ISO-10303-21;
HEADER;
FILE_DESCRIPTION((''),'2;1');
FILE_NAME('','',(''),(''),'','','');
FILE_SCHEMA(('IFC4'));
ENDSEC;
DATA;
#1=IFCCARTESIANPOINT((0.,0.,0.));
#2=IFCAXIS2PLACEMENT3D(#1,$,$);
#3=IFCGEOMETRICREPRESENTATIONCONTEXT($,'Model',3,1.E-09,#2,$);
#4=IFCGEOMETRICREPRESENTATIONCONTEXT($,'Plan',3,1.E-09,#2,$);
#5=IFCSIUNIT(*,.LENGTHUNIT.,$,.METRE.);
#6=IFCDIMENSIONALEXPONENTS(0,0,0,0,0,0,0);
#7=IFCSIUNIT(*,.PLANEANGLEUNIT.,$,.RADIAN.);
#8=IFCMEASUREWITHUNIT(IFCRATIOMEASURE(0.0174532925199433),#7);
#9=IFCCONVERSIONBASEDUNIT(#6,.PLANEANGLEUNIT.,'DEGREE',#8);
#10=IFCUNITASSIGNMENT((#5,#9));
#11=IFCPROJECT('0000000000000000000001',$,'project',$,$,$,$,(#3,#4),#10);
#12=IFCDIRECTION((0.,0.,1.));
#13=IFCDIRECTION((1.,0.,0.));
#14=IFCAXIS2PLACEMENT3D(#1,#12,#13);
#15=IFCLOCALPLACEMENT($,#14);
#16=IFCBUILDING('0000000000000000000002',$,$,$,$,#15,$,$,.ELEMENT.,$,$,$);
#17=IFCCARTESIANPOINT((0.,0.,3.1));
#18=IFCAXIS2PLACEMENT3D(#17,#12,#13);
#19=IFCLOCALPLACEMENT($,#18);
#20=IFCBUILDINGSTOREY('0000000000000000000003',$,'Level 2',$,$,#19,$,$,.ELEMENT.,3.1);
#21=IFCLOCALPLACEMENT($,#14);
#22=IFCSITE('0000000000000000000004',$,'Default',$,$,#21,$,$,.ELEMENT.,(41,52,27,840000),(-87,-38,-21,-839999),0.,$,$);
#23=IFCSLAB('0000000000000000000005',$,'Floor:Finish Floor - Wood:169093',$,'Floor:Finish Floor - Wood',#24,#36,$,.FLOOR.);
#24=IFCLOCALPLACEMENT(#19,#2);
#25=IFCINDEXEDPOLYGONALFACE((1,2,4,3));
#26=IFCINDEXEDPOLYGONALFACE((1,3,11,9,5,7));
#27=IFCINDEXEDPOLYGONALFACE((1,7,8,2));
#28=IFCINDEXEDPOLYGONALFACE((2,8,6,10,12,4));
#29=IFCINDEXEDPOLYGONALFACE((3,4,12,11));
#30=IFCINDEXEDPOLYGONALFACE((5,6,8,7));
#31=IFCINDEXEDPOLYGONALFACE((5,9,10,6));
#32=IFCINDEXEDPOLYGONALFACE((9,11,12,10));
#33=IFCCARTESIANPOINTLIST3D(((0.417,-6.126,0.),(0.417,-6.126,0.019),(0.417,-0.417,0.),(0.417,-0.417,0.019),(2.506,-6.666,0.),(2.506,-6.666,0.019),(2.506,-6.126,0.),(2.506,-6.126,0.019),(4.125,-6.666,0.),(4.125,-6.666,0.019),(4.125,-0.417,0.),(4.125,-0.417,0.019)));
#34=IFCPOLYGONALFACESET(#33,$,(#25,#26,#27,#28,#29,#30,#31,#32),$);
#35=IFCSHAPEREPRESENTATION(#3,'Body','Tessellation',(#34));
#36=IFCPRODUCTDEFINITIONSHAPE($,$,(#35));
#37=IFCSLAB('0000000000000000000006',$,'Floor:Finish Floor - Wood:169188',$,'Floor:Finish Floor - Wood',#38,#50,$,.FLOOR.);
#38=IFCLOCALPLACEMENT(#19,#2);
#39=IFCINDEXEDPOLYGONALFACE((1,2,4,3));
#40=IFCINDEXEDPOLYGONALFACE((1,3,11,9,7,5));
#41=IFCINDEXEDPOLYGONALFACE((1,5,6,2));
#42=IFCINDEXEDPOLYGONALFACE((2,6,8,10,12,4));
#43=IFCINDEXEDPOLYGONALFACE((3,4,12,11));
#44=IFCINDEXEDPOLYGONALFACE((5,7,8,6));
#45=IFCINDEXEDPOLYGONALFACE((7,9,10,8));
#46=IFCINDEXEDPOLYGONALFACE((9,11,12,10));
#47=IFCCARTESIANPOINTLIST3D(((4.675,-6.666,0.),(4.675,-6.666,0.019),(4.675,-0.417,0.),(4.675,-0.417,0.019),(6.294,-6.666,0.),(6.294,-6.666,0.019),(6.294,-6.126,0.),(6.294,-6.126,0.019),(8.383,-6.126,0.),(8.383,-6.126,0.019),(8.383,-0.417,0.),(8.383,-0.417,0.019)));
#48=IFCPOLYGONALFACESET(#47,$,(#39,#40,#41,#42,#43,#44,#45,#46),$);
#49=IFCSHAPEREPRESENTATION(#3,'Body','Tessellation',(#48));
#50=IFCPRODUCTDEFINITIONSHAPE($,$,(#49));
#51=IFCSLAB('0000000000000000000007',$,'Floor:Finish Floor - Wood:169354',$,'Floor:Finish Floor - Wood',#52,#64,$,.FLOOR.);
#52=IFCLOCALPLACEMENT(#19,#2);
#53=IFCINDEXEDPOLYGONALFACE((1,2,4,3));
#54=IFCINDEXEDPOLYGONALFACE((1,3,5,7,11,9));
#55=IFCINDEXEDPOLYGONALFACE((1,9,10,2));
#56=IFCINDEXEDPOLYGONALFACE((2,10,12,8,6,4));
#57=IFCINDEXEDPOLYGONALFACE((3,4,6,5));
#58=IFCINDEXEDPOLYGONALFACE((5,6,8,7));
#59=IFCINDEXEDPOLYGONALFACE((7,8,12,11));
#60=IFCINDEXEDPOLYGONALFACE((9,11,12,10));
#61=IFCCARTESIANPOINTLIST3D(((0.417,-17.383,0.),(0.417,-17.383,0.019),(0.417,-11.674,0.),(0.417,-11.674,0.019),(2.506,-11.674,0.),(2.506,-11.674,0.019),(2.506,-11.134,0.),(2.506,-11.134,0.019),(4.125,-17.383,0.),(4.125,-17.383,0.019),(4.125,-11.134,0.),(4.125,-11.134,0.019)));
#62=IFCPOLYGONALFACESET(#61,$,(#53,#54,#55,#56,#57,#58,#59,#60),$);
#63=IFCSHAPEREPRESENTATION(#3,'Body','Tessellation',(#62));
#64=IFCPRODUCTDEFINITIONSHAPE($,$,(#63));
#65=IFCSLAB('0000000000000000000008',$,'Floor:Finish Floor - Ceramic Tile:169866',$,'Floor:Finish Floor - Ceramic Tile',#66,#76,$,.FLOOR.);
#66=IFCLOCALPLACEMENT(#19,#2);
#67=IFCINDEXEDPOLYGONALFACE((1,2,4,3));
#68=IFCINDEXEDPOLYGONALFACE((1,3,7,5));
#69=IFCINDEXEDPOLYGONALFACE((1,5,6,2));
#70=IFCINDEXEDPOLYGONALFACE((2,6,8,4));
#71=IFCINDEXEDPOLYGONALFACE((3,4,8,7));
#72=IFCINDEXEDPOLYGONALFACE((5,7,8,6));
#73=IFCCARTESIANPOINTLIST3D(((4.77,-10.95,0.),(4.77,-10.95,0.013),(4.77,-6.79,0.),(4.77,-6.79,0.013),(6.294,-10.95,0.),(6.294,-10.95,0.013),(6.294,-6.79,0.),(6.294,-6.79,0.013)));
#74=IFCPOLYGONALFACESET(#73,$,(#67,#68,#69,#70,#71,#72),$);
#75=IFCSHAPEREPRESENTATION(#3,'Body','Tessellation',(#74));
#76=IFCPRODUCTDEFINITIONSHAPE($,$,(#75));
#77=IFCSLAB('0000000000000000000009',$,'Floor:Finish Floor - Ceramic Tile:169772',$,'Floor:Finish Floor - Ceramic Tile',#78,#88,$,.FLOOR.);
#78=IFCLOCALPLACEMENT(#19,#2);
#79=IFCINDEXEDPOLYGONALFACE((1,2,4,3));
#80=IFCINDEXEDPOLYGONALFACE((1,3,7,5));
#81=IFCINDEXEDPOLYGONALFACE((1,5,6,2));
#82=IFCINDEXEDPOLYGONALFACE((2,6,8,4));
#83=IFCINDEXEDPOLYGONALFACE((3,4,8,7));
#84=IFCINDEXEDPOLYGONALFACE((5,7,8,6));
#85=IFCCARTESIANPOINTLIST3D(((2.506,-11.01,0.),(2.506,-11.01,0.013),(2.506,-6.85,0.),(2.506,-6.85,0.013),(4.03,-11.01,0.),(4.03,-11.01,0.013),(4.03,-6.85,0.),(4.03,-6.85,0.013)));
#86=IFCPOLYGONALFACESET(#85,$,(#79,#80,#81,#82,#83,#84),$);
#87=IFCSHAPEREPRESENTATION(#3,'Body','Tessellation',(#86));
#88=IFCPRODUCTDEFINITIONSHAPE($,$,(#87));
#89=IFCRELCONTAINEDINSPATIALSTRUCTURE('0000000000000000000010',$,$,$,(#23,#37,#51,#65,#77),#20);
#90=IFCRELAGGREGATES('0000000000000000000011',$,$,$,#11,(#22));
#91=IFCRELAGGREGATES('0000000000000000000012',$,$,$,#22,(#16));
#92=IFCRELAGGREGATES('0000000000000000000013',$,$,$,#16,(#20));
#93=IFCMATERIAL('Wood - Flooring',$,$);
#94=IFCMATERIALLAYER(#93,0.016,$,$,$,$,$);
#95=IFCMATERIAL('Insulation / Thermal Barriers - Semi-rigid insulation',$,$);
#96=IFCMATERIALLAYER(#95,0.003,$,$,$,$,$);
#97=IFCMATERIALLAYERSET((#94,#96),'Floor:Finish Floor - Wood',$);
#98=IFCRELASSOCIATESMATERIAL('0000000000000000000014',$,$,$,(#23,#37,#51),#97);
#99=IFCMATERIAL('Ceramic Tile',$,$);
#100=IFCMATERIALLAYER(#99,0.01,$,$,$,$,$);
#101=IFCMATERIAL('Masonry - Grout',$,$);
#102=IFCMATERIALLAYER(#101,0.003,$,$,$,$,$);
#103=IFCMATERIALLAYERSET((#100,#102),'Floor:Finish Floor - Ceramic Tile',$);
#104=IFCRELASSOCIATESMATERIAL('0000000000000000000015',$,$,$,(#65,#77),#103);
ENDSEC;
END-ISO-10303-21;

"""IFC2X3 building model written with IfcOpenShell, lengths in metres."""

from ifc_helpers import new_model, entity, si_unit, converted_unit, frame, frame_2d, origin, origin_with_axes, place, context, project, spatial, polyline, rectangle, outline, extrude, material, layer, layer_set, layer_usage, element, save


model = new_model("IFC2X3")

# Units and contexts
model_context = context("Model", 3, precision=1e-09, world=origin())
plan_context = context("Plan", 3, precision=1e-09, world=origin())
ifc_project = project(units=[si_unit("LENGTHUNIT", "METRE"), converted_unit("PLANEANGLEUNIT", "DEGREE", entity("IfcRatioMeasure", 0.0174532925199433), si_unit("PLANEANGLEUNIT", "RADIAN"), dimensions=[0, 0, 0, 0, 0, 0, 0])], contexts=[model_context, plan_context])

# Site, building, storey
site_placement = place(None, origin_with_axes())
site = spatial("IfcSite", under=ifc_project, at=site_placement, Name="Default", CompositionType="ELEMENT", RefLatitude=(41, 52, 27, 840000), RefLongitude=(-87, -38, -21, -839999), RefElevation=0.0)
building_placement = place(None, origin_with_axes())
building = spatial("IfcBuilding", under=site, at=building_placement, CompositionType="ELEMENT")
storey_placement = place(None, frame((0.0, 0.0, 3.1), z_axis=(0.0, 0.0, 1.0), x_axis=(1.0, 0.0, 0.0)))
storey = spatial("IfcBuildingStorey", under=building, at=storey_placement, Name="Level 2", CompositionType="ELEMENT", Elevation=3.1)

# Slabs
ifc_material_1 = material(Name="Wood - Flooring")
ifc_layer_1 = layer(ifc_material_1, 0.016)
ifc_material_2 = material(Name="Insulation / Thermal Barriers - Semi-rigid insulation")
ifc_layer_2 = layer(ifc_material_2, 0.003)
ifc_layer_set_1 = layer_set([ifc_layer_1, ifc_layer_2], Name="Floor:Finish Floor - Wood")
ifc_layer_usage_1 = layer_usage(ifc_layer_set_1, "AXIS3", "POSITIVE", 0.0)
slab_1_placement = place(None, frame((0.417, -6.666, 3.1), z_axis=(0.0, 0.0, 1.0), x_axis=(1.0, 0.0, 0.0)))
element("IfcSlab", 1, at=slab_1_placement, inside=storey, material=ifc_layer_usage_1, Name="Floor:Finish Floor - Wood:169093", ObjectType="Floor:Finish Floor - Wood", PredefinedType="FLOOR", context=model_context, shape_type="SweptSolid", body=[
    extrude(outline(polyline([(1.854, 3.1245), (-1.854, 3.1245), (-1.854, -3.1245), (-0.235, -3.1245), (-0.235, -2.5845), (1.854, -2.5845), (1.854, 3.1245)])), frame((1.854, 3.1245, 0.019), z_axis=(0.0, 0.0, -1.0), x_axis=(-1.0, 0.0, 0.0)), (0.0, 0.0, 1.0), 0.019),
])
ifc_layer_usage_2 = layer_usage(ifc_layer_set_1, "AXIS3", "POSITIVE", 0.0)
slab_2_placement = place(None, frame((4.675, -6.666, 3.1), z_axis=(0.0, 0.0, 1.0), x_axis=(1.0, 0.0, 0.0)))
element("IfcSlab", 2, at=slab_2_placement, inside=storey, material=ifc_layer_usage_2, Name="Floor:Finish Floor - Wood:169188", ObjectType="Floor:Finish Floor - Wood", PredefinedType="FLOOR", context=model_context, shape_type="SweptSolid", body=[
    extrude(outline(polyline([(-1.854, 3.1245), (-1.854, -2.5845), (0.235, -2.5845), (0.235, -3.1245), (1.854, -3.1245), (1.854, 3.1245), (-1.854, 3.1245)])), frame((1.854, 3.1245, 0.019), z_axis=(0.0, 0.0, -1.0), x_axis=(-1.0, 0.0, 0.0)), (0.0, 0.0, 1.0), 0.019),
])
ifc_layer_usage_3 = layer_usage(ifc_layer_set_1, "AXIS3", "POSITIVE", 0.0)
slab_3_placement = place(None, frame((0.417, -17.383, 3.1), z_axis=(0.0, 0.0, 1.0), x_axis=(1.0, 0.0, 0.0)))
element("IfcSlab", 3, at=slab_3_placement, inside=storey, material=ifc_layer_usage_3, Name="Floor:Finish Floor - Wood:169354", ObjectType="Floor:Finish Floor - Wood", PredefinedType="FLOOR", context=model_context, shape_type="SweptSolid", body=[
    extrude(outline(polyline([(-1.854, -3.1245), (1.854, -3.1245), (1.854, 2.5845), (-0.235, 2.5845), (-0.235, 3.1245), (-1.854, 3.1245), (-1.854, -3.1245)])), frame((1.854, 3.1245, 0.019), z_axis=(0.0, 0.0, -1.0), x_axis=(-1.0, 0.0, 0.0)), (0.0, 0.0, 1.0), 0.019),
])
ifc_material_3 = material(Name="Ceramic Tile")
ifc_layer_3 = layer(ifc_material_3, 0.01)
ifc_material_4 = material(Name="Masonry - Grout")
ifc_layer_4 = layer(ifc_material_4, 0.003)
ifc_layer_set_2 = layer_set([ifc_layer_3, ifc_layer_4], Name="Floor:Finish Floor - Ceramic Tile")
ifc_layer_usage_4 = layer_usage(ifc_layer_set_2, "AXIS3", "POSITIVE", 0.0)
slab_4_placement = place(None, frame((4.77, -10.95, 3.1), z_axis=(0.0, 0.0, 1.0), x_axis=(1.0, 0.0, 0.0)))
element("IfcSlab", 4, at=slab_4_placement, inside=storey, material=ifc_layer_usage_4, Name="Floor:Finish Floor - Ceramic Tile:169866", ObjectType="Floor:Finish Floor - Ceramic Tile", PredefinedType="FLOOR", context=model_context, shape_type="SweptSolid", body=[
    extrude(rectangle(XDim=4.16, YDim=1.524, at=frame_2d((0.0, 0.0), x_axis=(0.0, -1.0))), frame((0.762, 2.08, 0.013), z_axis=(0.0, 0.0, -1.0), x_axis=(-1.0, 0.0, 0.0)), (0.0, 0.0, 1.0), 0.013),
])
ifc_layer_usage_5 = layer_usage(ifc_layer_set_2, "AXIS3", "POSITIVE", 0.0)
slab_5_placement = place(None, frame((2.506, -11.01, 3.1), z_axis=(0.0, 0.0, 1.0), x_axis=(1.0, 0.0, 0.0)))
element("IfcSlab", 5, at=slab_5_placement, inside=storey, material=ifc_layer_usage_5, Name="Floor:Finish Floor - Ceramic Tile:169772", ObjectType="Floor:Finish Floor - Ceramic Tile", PredefinedType="FLOOR", context=model_context, shape_type="SweptSolid", body=[
    extrude(rectangle(XDim=4.16, YDim=1.524, at=frame_2d((0.0, 0.0), x_axis=(0.0, -1.0))), frame((0.762, 2.08, 0.013), z_axis=(0.0, 0.0, -1.0), x_axis=(-1.0, 0.0, 0.0)), (0.0, 0.0, 1.0), 0.013),
])

save(model, "model.ifc")
